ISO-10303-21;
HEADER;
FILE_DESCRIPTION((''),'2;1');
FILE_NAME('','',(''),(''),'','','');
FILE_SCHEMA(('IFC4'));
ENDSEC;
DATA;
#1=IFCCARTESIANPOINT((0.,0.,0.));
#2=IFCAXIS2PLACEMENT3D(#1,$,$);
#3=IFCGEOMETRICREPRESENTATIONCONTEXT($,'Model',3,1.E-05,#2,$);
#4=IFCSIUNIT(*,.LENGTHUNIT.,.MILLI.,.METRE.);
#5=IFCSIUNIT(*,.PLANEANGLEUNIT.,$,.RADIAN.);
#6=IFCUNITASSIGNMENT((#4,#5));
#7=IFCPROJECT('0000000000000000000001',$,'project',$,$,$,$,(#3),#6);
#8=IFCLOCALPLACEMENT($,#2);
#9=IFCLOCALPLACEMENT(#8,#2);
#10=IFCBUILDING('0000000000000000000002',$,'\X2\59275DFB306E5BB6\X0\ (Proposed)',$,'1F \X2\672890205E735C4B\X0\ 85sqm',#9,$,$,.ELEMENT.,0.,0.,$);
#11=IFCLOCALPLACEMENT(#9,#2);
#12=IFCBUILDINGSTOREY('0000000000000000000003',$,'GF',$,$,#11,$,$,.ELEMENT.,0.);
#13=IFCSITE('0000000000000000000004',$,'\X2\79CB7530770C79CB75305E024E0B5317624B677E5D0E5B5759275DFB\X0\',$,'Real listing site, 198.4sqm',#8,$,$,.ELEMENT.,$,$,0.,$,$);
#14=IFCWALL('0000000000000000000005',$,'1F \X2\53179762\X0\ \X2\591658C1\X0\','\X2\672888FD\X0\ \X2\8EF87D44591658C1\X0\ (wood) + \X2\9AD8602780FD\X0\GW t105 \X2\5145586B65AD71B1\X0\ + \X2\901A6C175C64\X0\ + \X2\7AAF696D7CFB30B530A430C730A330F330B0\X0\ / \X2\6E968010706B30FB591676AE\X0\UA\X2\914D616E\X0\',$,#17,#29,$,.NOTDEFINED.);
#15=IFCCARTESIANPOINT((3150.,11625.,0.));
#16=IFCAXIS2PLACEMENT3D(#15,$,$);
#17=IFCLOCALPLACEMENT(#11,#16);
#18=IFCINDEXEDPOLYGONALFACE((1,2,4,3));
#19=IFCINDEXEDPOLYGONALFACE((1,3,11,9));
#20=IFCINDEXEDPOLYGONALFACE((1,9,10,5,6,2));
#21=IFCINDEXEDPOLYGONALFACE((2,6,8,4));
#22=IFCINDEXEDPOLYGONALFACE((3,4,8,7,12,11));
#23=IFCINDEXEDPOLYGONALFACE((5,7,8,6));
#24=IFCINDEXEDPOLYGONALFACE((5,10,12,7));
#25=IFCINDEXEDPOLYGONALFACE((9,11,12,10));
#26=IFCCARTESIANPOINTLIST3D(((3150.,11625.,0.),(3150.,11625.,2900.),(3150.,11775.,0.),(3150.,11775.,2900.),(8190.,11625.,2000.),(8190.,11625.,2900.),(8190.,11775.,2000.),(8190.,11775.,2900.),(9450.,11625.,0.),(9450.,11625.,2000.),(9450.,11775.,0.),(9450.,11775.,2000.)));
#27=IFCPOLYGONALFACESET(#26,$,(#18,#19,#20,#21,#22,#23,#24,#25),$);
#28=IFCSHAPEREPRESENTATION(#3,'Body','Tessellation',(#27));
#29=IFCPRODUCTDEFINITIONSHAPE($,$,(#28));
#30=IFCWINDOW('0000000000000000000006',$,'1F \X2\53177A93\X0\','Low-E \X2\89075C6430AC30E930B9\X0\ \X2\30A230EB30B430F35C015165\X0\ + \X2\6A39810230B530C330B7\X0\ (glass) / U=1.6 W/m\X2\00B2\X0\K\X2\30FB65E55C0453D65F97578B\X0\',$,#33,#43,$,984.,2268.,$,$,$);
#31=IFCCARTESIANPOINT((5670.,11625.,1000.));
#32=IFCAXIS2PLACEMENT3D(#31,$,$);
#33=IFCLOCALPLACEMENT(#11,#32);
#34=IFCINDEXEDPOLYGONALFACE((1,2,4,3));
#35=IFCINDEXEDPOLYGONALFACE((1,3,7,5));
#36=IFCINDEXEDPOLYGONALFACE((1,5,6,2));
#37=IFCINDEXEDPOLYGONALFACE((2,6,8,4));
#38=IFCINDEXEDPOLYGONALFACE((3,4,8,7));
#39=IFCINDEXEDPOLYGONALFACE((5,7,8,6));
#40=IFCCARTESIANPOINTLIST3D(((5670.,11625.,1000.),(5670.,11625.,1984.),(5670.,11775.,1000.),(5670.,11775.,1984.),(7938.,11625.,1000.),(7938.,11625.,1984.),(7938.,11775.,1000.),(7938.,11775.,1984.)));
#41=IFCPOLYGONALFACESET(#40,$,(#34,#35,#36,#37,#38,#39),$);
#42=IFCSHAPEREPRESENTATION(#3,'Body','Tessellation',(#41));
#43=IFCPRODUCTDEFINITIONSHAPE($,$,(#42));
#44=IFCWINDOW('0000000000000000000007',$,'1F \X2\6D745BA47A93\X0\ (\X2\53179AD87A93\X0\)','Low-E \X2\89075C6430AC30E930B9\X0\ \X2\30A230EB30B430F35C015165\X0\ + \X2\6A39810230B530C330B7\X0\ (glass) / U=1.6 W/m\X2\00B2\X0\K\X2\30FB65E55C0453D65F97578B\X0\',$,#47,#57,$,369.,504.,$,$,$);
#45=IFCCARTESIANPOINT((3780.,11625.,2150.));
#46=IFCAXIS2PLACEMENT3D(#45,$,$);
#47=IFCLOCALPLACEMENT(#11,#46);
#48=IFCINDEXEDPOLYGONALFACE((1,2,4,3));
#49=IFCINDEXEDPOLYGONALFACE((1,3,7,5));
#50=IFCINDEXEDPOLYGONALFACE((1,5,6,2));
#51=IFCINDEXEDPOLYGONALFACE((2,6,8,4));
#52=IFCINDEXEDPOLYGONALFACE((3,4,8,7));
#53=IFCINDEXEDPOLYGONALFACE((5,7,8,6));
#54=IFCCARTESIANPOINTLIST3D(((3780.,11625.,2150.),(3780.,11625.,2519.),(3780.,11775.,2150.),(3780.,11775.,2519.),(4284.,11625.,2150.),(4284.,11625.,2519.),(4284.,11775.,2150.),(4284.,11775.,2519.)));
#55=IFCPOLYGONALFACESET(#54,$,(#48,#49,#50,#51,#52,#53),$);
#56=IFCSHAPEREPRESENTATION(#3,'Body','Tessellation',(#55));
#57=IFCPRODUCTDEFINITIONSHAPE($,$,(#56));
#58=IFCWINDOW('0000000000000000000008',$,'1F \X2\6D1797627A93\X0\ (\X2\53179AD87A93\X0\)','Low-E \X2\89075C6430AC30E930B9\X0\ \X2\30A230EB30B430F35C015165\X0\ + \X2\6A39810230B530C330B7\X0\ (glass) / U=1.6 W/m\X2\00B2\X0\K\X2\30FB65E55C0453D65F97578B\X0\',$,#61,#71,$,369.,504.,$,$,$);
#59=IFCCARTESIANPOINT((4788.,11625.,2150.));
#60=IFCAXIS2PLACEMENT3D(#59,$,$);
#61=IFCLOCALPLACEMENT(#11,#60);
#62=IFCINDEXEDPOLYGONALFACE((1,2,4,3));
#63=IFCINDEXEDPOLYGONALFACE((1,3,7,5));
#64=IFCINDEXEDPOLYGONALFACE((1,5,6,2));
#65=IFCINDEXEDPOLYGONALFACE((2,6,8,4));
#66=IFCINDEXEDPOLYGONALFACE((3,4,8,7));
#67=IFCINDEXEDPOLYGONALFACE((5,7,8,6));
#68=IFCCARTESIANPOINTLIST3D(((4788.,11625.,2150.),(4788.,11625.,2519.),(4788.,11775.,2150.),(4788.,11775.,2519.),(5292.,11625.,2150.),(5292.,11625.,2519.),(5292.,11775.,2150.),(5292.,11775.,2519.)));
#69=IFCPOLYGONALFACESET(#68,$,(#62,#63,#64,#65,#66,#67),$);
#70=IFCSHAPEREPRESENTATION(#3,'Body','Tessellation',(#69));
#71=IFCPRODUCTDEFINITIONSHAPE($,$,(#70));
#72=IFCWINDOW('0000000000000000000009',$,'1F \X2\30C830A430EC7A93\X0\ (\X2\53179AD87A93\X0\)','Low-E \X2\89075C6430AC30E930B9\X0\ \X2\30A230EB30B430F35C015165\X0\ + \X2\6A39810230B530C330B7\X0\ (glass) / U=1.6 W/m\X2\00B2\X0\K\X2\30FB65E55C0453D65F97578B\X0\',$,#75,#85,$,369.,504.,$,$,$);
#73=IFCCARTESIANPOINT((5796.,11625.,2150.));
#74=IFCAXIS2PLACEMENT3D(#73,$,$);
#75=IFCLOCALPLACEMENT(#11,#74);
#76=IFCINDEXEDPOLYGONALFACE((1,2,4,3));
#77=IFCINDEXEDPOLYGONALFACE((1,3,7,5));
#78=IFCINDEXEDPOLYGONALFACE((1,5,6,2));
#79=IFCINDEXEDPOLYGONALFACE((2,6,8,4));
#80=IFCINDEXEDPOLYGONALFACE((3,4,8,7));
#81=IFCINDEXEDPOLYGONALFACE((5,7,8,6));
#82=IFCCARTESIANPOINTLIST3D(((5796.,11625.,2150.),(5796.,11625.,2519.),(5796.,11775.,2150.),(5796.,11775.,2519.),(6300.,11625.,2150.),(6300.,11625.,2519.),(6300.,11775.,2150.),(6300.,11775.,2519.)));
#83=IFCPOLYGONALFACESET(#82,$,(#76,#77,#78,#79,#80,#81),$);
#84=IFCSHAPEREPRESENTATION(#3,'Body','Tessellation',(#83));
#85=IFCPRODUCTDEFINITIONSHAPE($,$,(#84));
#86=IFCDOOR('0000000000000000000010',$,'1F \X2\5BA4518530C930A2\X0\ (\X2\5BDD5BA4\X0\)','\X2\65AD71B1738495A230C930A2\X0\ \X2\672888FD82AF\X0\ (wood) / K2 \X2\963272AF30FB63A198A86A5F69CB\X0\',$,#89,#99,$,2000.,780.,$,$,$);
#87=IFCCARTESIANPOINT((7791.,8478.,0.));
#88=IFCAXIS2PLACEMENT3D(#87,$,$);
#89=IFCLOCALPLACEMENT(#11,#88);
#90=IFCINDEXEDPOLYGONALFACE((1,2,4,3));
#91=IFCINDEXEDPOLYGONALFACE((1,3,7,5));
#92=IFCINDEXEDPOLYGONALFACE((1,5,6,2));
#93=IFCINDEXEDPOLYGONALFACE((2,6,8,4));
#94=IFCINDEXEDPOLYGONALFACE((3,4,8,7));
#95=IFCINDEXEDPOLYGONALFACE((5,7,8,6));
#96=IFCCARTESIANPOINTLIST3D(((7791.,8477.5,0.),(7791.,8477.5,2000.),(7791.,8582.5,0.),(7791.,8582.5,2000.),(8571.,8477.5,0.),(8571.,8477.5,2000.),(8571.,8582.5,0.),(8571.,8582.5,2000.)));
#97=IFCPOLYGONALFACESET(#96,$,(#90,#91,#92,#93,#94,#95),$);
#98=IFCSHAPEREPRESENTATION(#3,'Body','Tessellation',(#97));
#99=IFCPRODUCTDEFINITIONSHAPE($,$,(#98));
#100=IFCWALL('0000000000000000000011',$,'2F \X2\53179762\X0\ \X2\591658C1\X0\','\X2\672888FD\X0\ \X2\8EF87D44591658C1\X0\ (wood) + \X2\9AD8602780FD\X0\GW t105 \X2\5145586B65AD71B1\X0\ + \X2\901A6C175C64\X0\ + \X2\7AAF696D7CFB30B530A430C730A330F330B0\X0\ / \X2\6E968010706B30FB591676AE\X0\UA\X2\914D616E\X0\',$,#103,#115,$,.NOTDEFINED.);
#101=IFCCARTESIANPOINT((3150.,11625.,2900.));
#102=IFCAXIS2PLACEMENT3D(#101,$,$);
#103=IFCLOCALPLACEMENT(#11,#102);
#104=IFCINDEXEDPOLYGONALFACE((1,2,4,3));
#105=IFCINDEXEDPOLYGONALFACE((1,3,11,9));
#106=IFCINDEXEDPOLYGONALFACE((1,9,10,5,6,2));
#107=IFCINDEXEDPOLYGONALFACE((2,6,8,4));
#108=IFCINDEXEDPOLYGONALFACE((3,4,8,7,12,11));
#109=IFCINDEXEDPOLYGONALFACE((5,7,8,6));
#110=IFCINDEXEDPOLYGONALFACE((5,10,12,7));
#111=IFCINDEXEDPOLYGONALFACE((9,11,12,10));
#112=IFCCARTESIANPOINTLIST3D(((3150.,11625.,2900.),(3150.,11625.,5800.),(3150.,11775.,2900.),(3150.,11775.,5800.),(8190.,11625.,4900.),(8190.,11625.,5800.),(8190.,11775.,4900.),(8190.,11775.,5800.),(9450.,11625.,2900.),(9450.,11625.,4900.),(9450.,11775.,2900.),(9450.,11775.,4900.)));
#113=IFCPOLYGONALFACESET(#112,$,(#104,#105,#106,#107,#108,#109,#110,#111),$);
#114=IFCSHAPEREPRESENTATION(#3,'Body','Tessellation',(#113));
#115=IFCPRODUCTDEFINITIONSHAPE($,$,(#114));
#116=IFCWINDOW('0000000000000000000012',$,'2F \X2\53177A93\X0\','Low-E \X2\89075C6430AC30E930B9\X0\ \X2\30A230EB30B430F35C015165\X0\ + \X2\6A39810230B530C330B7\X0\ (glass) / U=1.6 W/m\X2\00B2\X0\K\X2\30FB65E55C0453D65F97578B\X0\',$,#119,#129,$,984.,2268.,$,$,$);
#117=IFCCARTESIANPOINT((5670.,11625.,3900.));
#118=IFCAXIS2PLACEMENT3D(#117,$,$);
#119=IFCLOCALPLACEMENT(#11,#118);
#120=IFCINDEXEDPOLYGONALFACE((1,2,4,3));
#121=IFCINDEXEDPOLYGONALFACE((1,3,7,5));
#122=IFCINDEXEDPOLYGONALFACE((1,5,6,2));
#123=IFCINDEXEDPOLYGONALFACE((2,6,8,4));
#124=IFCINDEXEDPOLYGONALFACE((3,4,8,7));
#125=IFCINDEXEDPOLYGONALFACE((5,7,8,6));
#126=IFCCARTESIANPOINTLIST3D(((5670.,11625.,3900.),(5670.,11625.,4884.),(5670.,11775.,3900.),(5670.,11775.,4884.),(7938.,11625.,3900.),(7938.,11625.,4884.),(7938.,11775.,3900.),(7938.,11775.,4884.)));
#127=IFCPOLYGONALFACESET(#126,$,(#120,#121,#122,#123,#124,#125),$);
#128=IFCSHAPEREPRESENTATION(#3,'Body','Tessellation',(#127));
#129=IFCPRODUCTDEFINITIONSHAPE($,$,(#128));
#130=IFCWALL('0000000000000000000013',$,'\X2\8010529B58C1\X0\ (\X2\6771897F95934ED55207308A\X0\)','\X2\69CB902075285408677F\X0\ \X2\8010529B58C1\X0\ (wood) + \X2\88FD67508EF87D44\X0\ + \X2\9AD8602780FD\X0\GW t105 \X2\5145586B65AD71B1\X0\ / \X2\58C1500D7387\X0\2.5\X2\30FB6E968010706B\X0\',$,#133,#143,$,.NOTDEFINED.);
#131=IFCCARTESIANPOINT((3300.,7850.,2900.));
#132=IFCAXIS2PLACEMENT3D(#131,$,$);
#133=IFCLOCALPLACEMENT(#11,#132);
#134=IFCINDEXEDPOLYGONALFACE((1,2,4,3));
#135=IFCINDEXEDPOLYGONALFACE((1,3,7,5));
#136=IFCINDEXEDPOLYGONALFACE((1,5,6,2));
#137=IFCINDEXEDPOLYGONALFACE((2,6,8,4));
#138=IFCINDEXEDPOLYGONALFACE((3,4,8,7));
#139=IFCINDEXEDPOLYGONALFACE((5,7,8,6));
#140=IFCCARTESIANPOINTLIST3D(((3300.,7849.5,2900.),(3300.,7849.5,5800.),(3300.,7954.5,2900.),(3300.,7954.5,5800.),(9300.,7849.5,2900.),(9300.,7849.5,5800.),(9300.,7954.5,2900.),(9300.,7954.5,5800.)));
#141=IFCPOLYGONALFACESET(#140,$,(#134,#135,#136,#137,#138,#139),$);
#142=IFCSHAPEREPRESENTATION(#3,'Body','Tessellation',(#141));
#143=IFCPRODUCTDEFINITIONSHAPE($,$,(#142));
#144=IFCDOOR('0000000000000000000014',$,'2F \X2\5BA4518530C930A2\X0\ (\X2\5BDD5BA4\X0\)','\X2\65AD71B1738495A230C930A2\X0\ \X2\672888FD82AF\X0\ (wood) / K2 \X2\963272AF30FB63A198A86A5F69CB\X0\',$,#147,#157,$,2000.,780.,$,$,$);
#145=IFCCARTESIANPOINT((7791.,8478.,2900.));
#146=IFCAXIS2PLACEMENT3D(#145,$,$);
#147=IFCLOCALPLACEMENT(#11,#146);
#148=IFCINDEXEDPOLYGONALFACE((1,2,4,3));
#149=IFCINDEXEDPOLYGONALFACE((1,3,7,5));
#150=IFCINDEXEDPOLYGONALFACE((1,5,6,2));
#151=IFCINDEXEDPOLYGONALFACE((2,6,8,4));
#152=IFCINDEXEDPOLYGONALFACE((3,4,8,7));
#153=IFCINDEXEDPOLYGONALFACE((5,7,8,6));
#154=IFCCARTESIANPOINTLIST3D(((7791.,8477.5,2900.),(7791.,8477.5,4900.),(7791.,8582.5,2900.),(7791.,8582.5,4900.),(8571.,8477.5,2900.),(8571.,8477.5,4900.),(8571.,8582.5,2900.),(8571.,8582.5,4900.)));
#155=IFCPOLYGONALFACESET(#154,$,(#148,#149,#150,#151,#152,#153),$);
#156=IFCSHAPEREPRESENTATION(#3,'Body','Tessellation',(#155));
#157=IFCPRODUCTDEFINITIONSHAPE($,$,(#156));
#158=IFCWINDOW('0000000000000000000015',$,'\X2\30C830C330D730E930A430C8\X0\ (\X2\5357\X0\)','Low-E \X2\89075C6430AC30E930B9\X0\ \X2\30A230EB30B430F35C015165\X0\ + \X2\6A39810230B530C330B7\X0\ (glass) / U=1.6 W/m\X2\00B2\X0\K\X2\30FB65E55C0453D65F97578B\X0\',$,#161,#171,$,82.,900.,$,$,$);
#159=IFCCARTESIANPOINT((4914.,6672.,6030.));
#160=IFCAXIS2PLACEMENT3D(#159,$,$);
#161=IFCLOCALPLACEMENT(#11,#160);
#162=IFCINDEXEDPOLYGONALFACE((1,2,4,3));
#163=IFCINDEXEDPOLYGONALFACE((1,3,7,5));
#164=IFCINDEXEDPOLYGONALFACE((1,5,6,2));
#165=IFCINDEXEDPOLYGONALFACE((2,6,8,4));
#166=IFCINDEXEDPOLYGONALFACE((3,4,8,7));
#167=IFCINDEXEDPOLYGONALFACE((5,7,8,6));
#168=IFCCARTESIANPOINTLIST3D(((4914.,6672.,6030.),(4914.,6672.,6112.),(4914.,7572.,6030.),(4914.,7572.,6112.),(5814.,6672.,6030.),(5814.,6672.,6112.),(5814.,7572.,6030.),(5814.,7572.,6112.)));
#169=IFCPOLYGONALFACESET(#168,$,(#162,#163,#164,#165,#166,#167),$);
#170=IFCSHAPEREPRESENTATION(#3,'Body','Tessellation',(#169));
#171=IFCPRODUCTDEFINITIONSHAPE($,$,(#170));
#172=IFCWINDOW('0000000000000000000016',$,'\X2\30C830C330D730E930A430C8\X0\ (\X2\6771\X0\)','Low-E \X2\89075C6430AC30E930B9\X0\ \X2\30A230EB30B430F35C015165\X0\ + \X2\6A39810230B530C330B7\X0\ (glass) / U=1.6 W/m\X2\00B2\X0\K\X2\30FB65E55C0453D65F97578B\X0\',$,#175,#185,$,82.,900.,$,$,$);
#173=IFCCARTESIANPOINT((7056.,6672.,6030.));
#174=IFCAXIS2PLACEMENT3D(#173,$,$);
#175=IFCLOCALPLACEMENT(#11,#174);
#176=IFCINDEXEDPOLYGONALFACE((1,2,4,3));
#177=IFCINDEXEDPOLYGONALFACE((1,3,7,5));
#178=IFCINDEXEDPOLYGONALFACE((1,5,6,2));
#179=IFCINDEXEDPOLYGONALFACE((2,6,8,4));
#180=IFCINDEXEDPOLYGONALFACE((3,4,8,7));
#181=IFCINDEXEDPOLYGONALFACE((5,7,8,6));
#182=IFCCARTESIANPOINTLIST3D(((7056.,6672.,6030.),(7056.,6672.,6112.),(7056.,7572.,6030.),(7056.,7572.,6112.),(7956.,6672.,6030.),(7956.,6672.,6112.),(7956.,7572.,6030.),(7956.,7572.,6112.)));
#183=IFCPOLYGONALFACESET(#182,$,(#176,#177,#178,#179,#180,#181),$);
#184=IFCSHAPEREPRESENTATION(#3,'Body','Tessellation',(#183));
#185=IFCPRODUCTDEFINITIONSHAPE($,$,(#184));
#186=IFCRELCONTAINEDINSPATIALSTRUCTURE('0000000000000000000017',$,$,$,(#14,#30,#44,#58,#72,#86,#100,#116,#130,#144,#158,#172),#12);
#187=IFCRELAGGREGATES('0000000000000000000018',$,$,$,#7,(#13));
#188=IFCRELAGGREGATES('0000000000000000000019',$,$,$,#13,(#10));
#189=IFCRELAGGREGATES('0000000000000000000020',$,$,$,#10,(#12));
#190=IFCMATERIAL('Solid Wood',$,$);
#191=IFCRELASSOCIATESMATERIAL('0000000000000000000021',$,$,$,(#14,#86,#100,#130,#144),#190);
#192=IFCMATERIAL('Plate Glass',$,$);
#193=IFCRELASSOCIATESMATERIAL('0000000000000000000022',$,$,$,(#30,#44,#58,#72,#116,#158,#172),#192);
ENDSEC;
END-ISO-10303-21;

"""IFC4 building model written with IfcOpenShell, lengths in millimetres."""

from ifc_helpers import new_model, si_unit, frame, frame_2d, origin, place, context, project, spatial, rectangle, extrude, material, element, fill, save


model = new_model("IFC4")

# Units and contexts
model_context = context("Model", 3, precision=1e-05, world=origin())
ifc_project = project(units=[si_unit("LENGTHUNIT", "METRE", prefix="MILLI"), si_unit("PLANEANGLEUNIT", "RADIAN")], contexts=[model_context])

# Site, building, storey
site_placement = place(None, origin())
site = spatial("IfcSite", under=ifc_project, at=site_placement, Name="秋田県秋田市下北手松崎字大巻", ObjectType="Real listing site, 198.4sqm", CompositionType="ELEMENT", RefElevation=0.0)
building_placement = place(site_placement, origin())
building = spatial("IfcBuilding", under=site, at=building_placement, Name="大巻の家 (Proposed)", ObjectType="1F 木造平屋 85sqm", CompositionType="ELEMENT", ElevationOfRefHeight=0.0, ElevationOfTerrain=0.0)
storey_placement = place(building_placement, origin())
storey = spatial("IfcBuildingStorey", under=building, at=storey_placement, Name="GF", CompositionType="ELEMENT", Elevation=0.0)

# Wall, openings, windows
ifc_material_1 = material(Name="Solid Wood")
wall_1_placement = place(storey_placement, frame((3150.0, 11625.0, 0.0)))
wall_1 = element("IfcWall", 1, at=wall_1_placement, inside=storey, material=ifc_material_1, Name="1F 北面 外壁", Description="木製 軸組外壁 (wood) + 高性能GW t105 充填断熱 + 通気層 + 窯業系サイディング / 準耐火・外皮UA配慮", PredefinedType="NOTDEFINED", context=model_context, shape_type="SweptSolid", body=[
    extrude(rectangle(XDim=6300.0, YDim=150.0, at=frame_2d((3150.0, 75.0))), frame((3150.0, 11625.0, 0.0)), (0.0, 0.0, 1.0), 2900.0),
])
opening_1_placement = place(storey_placement, frame((5670.0, 11625.0, 1000.0)))
opening_1 = element("IfcOpeningElement", 2, at=opening_1_placement, cuts=wall_1, PredefinedType="NOTDEFINED", context=model_context, shape_type="SweptSolid", body=[
    extrude(rectangle(XDim=2268.0, YDim=150.0, at=frame_2d((1134.0, 75.0))), frame((5670.0, 11625.0, 1000.0)), (0.0, 0.0, 1.0), 984.0),
])
opening_2_placement = place(storey_placement, frame((3780.0, 11625.0, 2150.0)))
opening_2 = element("IfcOpeningElement", 3, at=opening_2_placement, cuts=wall_1, PredefinedType="NOTDEFINED", context=model_context, shape_type="SweptSolid", body=[
    extrude(rectangle(XDim=504.0, YDim=150.0, at=frame_2d((252.0, 75.0))), frame((3780.0, 11625.0, 2150.0)), (0.0, 0.0, 1.0), 369.0),
])
opening_3_placement = place(storey_placement, frame((4788.0, 11625.0, 2150.0)))
opening_3 = element("IfcOpeningElement", 4, at=opening_3_placement, cuts=wall_1, PredefinedType="NOTDEFINED", context=model_context, shape_type="SweptSolid", body=[
    extrude(rectangle(XDim=504.0, YDim=150.0, at=frame_2d((252.0, 75.0))), frame((4788.0, 11625.0, 2150.0)), (0.0, 0.0, 1.0), 369.0),
])
opening_4_placement = place(storey_placement, frame((5796.0, 11625.0, 2150.0)))
opening_4 = element("IfcOpeningElement", 5, at=opening_4_placement, cuts=wall_1, PredefinedType="NOTDEFINED", context=model_context, shape_type="SweptSolid", body=[
    extrude(rectangle(XDim=504.0, YDim=150.0, at=frame_2d((252.0, 75.0))), frame((5796.0, 11625.0, 2150.0)), (0.0, 0.0, 1.0), 369.0),
])
ifc_material_2 = material(Name="Plate Glass")
window_1_placement = place(storey_placement, frame((5670.0, 11625.0, 1000.0)))
window_1 = element("IfcWindow", 6, at=window_1_placement, inside=storey, material=ifc_material_2, Name="1F 北窓", Description="Low-E 複層ガラス アルゴン封入 + 樹脂サッシ (glass) / U=1.6 W/m²K・日射取得型", OverallHeight=984.0, OverallWidth=2268.0, context=model_context, shape_type="SweptSolid", body=[
    extrude(rectangle(XDim=2268.0, YDim=150.0, at=frame_2d((1134.0, 75.0))), frame((5670.0, 11625.0, 1000.0)), (0.0, 0.0, 1.0), 984.0),
])
fill(opening_1, window_1)
window_2_placement = place(storey_placement, frame((3780.0, 11625.0, 2150.0)))
window_2 = element("IfcWindow", 7, at=window_2_placement, inside=storey, material=ifc_material_2, Name="1F 浴室窓 (北高窓)", Description="Low-E 複層ガラス アルゴン封入 + 樹脂サッシ (glass) / U=1.6 W/m²K・日射取得型", OverallHeight=369.0, OverallWidth=504.0, context=model_context, shape_type="SweptSolid", body=[
    extrude(rectangle(XDim=504.0, YDim=150.0, at=frame_2d((252.0, 75.0))), frame((3780.0, 11625.0, 2150.0)), (0.0, 0.0, 1.0), 369.0),
])
fill(opening_2, window_2)
window_3_placement = place(storey_placement, frame((4788.0, 11625.0, 2150.0)))
window_3 = element("IfcWindow", 8, at=window_3_placement, inside=storey, material=ifc_material_2, Name="1F 洗面窓 (北高窓)", Description="Low-E 複層ガラス アルゴン封入 + 樹脂サッシ (glass) / U=1.6 W/m²K・日射取得型", OverallHeight=369.0, OverallWidth=504.0, context=model_context, shape_type="SweptSolid", body=[
    extrude(rectangle(XDim=504.0, YDim=150.0, at=frame_2d((252.0, 75.0))), frame((4788.0, 11625.0, 2150.0)), (0.0, 0.0, 1.0), 369.0),
])
fill(opening_3, window_3)
window_4_placement = place(storey_placement, frame((5796.0, 11625.0, 2150.0)))
window_4 = element("IfcWindow", 9, at=window_4_placement, inside=storey, material=ifc_material_2, Name="1F トイレ窓 (北高窓)", Description="Low-E 複層ガラス アルゴン封入 + 樹脂サッシ (glass) / U=1.6 W/m²K・日射取得型", OverallHeight=369.0, OverallWidth=504.0, context=model_context, shape_type="SweptSolid", body=[
    extrude(rectangle(XDim=504.0, YDim=150.0, at=frame_2d((252.0, 75.0))), frame((5796.0, 11625.0, 2150.0)), (0.0, 0.0, 1.0), 369.0),
])
fill(opening_4, window_4)

# Door
door_1_placement = place(storey_placement, frame((7791.0, 8478.0, 0.0)))
element("IfcDoor", 10, at=door_1_placement, inside=storey, material=ifc_material_1, Name="1F 室内ドア (寝室)", Description="断熱玄関ドア 木製芯 (wood) / K2 防犯・採風機構", OverallHeight=2000.0, OverallWidth=780.0, context=model_context, shape_type="SweptSolid", body=[
    extrude(rectangle(XDim=780.0, YDim=105.0, at=frame_2d((390.0, 52.0))), frame((7791.0, 8478.0, 0.0)), (0.0, 0.0, 1.0), 2000.0),
])

# Wall, opening, window
wall_2_placement = place(storey_placement, frame((3150.0, 11625.0, 2900.0)))
wall_2 = element("IfcWall", 11, at=wall_2_placement, inside=storey, material=ifc_material_1, Name="2F 北面 外壁", Description="木製 軸組外壁 (wood) + 高性能GW t105 充填断熱 + 通気層 + 窯業系サイディング / 準耐火・外皮UA配慮", PredefinedType="NOTDEFINED", context=model_context, shape_type="SweptSolid", body=[
    extrude(rectangle(XDim=6300.0, YDim=150.0, at=frame_2d((3150.0, 75.0))), frame((3150.0, 11625.0, 2900.0)), (0.0, 0.0, 1.0), 2900.0),
])
opening_5_placement = place(storey_placement, frame((5670.0, 11625.0, 3900.0)))
opening_5 = element("IfcOpeningElement", 12, at=opening_5_placement, cuts=wall_2, PredefinedType="NOTDEFINED", context=model_context, shape_type="SweptSolid", body=[
    extrude(rectangle(XDim=2268.0, YDim=150.0, at=frame_2d((1134.0, 75.0))), frame((5670.0, 11625.0, 3900.0)), (0.0, 0.0, 1.0), 984.0),
])
window_5_placement = place(storey_placement, frame((5670.0, 11625.0, 3900.0)))
window_5 = element("IfcWindow", 13, at=window_5_placement, inside=storey, material=ifc_material_2, Name="2F 北窓", Description="Low-E 複層ガラス アルゴン封入 + 樹脂サッシ (glass) / U=1.6 W/m²K・日射取得型", OverallHeight=984.0, OverallWidth=2268.0, context=model_context, shape_type="SweptSolid", body=[
    extrude(rectangle(XDim=2268.0, YDim=150.0, at=frame_2d((1134.0, 75.0))), frame((5670.0, 11625.0, 3900.0)), (0.0, 0.0, 1.0), 984.0),
])
fill(opening_5, window_5)

# Wall
wall_3_placement = place(storey_placement, frame((3300.0, 7850.0, 2900.0)))
element("IfcWall", 14, at=wall_3_placement, inside=storey, material=ifc_material_1, Name="耐力壁 (東西間仕切り)", Description="構造用合板 耐力壁 (wood) + 製材軸組 + 高性能GW t105 充填断熱 / 壁倍率2.5・準耐火", PredefinedType="NOTDEFINED", context=model_context, shape_type="SweptSolid", body=[
    extrude(rectangle(XDim=6000.0, YDim=105.0, at=frame_2d((3000.0, 52.0))), frame((3300.0, 7850.0, 2900.0)), (0.0, 0.0, 1.0), 2900.0),
])

# Door
door_2_placement = place(storey_placement, frame((7791.0, 8478.0, 2900.0)))
element("IfcDoor", 15, at=door_2_placement, inside=storey, material=ifc_material_1, Name="2F 室内ドア (寝室)", Description="断熱玄関ドア 木製芯 (wood) / K2 防犯・採風機構", OverallHeight=2000.0, OverallWidth=780.0, context=model_context, shape_type="SweptSolid", body=[
    extrude(rectangle(XDim=780.0, YDim=105.0, at=frame_2d((390.0, 52.0))), frame((7791.0, 8478.0, 2900.0)), (0.0, 0.0, 1.0), 2000.0),
])

# Windows
window_6_placement = place(storey_placement, frame((4914.0, 6672.0, 6030.0)))
element("IfcWindow", 16, at=window_6_placement, inside=storey, material=ifc_material_2, Name="トップライト (南)", Description="Low-E 複層ガラス アルゴン封入 + 樹脂サッシ (glass) / U=1.6 W/m²K・日射取得型", OverallHeight=82.0, OverallWidth=900.0, context=model_context, shape_type="SweptSolid", body=[
    extrude(rectangle(XDim=900.0, YDim=900.0, at=frame_2d((450.0, 450.0))), frame((4914.0, 6672.0, 6030.0)), (0.0, 0.0, 1.0), 82.0),
])
window_7_placement = place(storey_placement, frame((7056.0, 6672.0, 6030.0)))
element("IfcWindow", 17, at=window_7_placement, inside=storey, material=ifc_material_2, Name="トップライト (東)", Description="Low-E 複層ガラス アルゴン封入 + 樹脂サッシ (glass) / U=1.6 W/m²K・日射取得型", OverallHeight=82.0, OverallWidth=900.0, context=model_context, shape_type="SweptSolid", body=[
    extrude(rectangle(XDim=900.0, YDim=900.0, at=frame_2d((450.0, 450.0))), frame((7056.0, 6672.0, 6030.0)), (0.0, 0.0, 1.0), 82.0),
])

save(model, "model.ifc")
